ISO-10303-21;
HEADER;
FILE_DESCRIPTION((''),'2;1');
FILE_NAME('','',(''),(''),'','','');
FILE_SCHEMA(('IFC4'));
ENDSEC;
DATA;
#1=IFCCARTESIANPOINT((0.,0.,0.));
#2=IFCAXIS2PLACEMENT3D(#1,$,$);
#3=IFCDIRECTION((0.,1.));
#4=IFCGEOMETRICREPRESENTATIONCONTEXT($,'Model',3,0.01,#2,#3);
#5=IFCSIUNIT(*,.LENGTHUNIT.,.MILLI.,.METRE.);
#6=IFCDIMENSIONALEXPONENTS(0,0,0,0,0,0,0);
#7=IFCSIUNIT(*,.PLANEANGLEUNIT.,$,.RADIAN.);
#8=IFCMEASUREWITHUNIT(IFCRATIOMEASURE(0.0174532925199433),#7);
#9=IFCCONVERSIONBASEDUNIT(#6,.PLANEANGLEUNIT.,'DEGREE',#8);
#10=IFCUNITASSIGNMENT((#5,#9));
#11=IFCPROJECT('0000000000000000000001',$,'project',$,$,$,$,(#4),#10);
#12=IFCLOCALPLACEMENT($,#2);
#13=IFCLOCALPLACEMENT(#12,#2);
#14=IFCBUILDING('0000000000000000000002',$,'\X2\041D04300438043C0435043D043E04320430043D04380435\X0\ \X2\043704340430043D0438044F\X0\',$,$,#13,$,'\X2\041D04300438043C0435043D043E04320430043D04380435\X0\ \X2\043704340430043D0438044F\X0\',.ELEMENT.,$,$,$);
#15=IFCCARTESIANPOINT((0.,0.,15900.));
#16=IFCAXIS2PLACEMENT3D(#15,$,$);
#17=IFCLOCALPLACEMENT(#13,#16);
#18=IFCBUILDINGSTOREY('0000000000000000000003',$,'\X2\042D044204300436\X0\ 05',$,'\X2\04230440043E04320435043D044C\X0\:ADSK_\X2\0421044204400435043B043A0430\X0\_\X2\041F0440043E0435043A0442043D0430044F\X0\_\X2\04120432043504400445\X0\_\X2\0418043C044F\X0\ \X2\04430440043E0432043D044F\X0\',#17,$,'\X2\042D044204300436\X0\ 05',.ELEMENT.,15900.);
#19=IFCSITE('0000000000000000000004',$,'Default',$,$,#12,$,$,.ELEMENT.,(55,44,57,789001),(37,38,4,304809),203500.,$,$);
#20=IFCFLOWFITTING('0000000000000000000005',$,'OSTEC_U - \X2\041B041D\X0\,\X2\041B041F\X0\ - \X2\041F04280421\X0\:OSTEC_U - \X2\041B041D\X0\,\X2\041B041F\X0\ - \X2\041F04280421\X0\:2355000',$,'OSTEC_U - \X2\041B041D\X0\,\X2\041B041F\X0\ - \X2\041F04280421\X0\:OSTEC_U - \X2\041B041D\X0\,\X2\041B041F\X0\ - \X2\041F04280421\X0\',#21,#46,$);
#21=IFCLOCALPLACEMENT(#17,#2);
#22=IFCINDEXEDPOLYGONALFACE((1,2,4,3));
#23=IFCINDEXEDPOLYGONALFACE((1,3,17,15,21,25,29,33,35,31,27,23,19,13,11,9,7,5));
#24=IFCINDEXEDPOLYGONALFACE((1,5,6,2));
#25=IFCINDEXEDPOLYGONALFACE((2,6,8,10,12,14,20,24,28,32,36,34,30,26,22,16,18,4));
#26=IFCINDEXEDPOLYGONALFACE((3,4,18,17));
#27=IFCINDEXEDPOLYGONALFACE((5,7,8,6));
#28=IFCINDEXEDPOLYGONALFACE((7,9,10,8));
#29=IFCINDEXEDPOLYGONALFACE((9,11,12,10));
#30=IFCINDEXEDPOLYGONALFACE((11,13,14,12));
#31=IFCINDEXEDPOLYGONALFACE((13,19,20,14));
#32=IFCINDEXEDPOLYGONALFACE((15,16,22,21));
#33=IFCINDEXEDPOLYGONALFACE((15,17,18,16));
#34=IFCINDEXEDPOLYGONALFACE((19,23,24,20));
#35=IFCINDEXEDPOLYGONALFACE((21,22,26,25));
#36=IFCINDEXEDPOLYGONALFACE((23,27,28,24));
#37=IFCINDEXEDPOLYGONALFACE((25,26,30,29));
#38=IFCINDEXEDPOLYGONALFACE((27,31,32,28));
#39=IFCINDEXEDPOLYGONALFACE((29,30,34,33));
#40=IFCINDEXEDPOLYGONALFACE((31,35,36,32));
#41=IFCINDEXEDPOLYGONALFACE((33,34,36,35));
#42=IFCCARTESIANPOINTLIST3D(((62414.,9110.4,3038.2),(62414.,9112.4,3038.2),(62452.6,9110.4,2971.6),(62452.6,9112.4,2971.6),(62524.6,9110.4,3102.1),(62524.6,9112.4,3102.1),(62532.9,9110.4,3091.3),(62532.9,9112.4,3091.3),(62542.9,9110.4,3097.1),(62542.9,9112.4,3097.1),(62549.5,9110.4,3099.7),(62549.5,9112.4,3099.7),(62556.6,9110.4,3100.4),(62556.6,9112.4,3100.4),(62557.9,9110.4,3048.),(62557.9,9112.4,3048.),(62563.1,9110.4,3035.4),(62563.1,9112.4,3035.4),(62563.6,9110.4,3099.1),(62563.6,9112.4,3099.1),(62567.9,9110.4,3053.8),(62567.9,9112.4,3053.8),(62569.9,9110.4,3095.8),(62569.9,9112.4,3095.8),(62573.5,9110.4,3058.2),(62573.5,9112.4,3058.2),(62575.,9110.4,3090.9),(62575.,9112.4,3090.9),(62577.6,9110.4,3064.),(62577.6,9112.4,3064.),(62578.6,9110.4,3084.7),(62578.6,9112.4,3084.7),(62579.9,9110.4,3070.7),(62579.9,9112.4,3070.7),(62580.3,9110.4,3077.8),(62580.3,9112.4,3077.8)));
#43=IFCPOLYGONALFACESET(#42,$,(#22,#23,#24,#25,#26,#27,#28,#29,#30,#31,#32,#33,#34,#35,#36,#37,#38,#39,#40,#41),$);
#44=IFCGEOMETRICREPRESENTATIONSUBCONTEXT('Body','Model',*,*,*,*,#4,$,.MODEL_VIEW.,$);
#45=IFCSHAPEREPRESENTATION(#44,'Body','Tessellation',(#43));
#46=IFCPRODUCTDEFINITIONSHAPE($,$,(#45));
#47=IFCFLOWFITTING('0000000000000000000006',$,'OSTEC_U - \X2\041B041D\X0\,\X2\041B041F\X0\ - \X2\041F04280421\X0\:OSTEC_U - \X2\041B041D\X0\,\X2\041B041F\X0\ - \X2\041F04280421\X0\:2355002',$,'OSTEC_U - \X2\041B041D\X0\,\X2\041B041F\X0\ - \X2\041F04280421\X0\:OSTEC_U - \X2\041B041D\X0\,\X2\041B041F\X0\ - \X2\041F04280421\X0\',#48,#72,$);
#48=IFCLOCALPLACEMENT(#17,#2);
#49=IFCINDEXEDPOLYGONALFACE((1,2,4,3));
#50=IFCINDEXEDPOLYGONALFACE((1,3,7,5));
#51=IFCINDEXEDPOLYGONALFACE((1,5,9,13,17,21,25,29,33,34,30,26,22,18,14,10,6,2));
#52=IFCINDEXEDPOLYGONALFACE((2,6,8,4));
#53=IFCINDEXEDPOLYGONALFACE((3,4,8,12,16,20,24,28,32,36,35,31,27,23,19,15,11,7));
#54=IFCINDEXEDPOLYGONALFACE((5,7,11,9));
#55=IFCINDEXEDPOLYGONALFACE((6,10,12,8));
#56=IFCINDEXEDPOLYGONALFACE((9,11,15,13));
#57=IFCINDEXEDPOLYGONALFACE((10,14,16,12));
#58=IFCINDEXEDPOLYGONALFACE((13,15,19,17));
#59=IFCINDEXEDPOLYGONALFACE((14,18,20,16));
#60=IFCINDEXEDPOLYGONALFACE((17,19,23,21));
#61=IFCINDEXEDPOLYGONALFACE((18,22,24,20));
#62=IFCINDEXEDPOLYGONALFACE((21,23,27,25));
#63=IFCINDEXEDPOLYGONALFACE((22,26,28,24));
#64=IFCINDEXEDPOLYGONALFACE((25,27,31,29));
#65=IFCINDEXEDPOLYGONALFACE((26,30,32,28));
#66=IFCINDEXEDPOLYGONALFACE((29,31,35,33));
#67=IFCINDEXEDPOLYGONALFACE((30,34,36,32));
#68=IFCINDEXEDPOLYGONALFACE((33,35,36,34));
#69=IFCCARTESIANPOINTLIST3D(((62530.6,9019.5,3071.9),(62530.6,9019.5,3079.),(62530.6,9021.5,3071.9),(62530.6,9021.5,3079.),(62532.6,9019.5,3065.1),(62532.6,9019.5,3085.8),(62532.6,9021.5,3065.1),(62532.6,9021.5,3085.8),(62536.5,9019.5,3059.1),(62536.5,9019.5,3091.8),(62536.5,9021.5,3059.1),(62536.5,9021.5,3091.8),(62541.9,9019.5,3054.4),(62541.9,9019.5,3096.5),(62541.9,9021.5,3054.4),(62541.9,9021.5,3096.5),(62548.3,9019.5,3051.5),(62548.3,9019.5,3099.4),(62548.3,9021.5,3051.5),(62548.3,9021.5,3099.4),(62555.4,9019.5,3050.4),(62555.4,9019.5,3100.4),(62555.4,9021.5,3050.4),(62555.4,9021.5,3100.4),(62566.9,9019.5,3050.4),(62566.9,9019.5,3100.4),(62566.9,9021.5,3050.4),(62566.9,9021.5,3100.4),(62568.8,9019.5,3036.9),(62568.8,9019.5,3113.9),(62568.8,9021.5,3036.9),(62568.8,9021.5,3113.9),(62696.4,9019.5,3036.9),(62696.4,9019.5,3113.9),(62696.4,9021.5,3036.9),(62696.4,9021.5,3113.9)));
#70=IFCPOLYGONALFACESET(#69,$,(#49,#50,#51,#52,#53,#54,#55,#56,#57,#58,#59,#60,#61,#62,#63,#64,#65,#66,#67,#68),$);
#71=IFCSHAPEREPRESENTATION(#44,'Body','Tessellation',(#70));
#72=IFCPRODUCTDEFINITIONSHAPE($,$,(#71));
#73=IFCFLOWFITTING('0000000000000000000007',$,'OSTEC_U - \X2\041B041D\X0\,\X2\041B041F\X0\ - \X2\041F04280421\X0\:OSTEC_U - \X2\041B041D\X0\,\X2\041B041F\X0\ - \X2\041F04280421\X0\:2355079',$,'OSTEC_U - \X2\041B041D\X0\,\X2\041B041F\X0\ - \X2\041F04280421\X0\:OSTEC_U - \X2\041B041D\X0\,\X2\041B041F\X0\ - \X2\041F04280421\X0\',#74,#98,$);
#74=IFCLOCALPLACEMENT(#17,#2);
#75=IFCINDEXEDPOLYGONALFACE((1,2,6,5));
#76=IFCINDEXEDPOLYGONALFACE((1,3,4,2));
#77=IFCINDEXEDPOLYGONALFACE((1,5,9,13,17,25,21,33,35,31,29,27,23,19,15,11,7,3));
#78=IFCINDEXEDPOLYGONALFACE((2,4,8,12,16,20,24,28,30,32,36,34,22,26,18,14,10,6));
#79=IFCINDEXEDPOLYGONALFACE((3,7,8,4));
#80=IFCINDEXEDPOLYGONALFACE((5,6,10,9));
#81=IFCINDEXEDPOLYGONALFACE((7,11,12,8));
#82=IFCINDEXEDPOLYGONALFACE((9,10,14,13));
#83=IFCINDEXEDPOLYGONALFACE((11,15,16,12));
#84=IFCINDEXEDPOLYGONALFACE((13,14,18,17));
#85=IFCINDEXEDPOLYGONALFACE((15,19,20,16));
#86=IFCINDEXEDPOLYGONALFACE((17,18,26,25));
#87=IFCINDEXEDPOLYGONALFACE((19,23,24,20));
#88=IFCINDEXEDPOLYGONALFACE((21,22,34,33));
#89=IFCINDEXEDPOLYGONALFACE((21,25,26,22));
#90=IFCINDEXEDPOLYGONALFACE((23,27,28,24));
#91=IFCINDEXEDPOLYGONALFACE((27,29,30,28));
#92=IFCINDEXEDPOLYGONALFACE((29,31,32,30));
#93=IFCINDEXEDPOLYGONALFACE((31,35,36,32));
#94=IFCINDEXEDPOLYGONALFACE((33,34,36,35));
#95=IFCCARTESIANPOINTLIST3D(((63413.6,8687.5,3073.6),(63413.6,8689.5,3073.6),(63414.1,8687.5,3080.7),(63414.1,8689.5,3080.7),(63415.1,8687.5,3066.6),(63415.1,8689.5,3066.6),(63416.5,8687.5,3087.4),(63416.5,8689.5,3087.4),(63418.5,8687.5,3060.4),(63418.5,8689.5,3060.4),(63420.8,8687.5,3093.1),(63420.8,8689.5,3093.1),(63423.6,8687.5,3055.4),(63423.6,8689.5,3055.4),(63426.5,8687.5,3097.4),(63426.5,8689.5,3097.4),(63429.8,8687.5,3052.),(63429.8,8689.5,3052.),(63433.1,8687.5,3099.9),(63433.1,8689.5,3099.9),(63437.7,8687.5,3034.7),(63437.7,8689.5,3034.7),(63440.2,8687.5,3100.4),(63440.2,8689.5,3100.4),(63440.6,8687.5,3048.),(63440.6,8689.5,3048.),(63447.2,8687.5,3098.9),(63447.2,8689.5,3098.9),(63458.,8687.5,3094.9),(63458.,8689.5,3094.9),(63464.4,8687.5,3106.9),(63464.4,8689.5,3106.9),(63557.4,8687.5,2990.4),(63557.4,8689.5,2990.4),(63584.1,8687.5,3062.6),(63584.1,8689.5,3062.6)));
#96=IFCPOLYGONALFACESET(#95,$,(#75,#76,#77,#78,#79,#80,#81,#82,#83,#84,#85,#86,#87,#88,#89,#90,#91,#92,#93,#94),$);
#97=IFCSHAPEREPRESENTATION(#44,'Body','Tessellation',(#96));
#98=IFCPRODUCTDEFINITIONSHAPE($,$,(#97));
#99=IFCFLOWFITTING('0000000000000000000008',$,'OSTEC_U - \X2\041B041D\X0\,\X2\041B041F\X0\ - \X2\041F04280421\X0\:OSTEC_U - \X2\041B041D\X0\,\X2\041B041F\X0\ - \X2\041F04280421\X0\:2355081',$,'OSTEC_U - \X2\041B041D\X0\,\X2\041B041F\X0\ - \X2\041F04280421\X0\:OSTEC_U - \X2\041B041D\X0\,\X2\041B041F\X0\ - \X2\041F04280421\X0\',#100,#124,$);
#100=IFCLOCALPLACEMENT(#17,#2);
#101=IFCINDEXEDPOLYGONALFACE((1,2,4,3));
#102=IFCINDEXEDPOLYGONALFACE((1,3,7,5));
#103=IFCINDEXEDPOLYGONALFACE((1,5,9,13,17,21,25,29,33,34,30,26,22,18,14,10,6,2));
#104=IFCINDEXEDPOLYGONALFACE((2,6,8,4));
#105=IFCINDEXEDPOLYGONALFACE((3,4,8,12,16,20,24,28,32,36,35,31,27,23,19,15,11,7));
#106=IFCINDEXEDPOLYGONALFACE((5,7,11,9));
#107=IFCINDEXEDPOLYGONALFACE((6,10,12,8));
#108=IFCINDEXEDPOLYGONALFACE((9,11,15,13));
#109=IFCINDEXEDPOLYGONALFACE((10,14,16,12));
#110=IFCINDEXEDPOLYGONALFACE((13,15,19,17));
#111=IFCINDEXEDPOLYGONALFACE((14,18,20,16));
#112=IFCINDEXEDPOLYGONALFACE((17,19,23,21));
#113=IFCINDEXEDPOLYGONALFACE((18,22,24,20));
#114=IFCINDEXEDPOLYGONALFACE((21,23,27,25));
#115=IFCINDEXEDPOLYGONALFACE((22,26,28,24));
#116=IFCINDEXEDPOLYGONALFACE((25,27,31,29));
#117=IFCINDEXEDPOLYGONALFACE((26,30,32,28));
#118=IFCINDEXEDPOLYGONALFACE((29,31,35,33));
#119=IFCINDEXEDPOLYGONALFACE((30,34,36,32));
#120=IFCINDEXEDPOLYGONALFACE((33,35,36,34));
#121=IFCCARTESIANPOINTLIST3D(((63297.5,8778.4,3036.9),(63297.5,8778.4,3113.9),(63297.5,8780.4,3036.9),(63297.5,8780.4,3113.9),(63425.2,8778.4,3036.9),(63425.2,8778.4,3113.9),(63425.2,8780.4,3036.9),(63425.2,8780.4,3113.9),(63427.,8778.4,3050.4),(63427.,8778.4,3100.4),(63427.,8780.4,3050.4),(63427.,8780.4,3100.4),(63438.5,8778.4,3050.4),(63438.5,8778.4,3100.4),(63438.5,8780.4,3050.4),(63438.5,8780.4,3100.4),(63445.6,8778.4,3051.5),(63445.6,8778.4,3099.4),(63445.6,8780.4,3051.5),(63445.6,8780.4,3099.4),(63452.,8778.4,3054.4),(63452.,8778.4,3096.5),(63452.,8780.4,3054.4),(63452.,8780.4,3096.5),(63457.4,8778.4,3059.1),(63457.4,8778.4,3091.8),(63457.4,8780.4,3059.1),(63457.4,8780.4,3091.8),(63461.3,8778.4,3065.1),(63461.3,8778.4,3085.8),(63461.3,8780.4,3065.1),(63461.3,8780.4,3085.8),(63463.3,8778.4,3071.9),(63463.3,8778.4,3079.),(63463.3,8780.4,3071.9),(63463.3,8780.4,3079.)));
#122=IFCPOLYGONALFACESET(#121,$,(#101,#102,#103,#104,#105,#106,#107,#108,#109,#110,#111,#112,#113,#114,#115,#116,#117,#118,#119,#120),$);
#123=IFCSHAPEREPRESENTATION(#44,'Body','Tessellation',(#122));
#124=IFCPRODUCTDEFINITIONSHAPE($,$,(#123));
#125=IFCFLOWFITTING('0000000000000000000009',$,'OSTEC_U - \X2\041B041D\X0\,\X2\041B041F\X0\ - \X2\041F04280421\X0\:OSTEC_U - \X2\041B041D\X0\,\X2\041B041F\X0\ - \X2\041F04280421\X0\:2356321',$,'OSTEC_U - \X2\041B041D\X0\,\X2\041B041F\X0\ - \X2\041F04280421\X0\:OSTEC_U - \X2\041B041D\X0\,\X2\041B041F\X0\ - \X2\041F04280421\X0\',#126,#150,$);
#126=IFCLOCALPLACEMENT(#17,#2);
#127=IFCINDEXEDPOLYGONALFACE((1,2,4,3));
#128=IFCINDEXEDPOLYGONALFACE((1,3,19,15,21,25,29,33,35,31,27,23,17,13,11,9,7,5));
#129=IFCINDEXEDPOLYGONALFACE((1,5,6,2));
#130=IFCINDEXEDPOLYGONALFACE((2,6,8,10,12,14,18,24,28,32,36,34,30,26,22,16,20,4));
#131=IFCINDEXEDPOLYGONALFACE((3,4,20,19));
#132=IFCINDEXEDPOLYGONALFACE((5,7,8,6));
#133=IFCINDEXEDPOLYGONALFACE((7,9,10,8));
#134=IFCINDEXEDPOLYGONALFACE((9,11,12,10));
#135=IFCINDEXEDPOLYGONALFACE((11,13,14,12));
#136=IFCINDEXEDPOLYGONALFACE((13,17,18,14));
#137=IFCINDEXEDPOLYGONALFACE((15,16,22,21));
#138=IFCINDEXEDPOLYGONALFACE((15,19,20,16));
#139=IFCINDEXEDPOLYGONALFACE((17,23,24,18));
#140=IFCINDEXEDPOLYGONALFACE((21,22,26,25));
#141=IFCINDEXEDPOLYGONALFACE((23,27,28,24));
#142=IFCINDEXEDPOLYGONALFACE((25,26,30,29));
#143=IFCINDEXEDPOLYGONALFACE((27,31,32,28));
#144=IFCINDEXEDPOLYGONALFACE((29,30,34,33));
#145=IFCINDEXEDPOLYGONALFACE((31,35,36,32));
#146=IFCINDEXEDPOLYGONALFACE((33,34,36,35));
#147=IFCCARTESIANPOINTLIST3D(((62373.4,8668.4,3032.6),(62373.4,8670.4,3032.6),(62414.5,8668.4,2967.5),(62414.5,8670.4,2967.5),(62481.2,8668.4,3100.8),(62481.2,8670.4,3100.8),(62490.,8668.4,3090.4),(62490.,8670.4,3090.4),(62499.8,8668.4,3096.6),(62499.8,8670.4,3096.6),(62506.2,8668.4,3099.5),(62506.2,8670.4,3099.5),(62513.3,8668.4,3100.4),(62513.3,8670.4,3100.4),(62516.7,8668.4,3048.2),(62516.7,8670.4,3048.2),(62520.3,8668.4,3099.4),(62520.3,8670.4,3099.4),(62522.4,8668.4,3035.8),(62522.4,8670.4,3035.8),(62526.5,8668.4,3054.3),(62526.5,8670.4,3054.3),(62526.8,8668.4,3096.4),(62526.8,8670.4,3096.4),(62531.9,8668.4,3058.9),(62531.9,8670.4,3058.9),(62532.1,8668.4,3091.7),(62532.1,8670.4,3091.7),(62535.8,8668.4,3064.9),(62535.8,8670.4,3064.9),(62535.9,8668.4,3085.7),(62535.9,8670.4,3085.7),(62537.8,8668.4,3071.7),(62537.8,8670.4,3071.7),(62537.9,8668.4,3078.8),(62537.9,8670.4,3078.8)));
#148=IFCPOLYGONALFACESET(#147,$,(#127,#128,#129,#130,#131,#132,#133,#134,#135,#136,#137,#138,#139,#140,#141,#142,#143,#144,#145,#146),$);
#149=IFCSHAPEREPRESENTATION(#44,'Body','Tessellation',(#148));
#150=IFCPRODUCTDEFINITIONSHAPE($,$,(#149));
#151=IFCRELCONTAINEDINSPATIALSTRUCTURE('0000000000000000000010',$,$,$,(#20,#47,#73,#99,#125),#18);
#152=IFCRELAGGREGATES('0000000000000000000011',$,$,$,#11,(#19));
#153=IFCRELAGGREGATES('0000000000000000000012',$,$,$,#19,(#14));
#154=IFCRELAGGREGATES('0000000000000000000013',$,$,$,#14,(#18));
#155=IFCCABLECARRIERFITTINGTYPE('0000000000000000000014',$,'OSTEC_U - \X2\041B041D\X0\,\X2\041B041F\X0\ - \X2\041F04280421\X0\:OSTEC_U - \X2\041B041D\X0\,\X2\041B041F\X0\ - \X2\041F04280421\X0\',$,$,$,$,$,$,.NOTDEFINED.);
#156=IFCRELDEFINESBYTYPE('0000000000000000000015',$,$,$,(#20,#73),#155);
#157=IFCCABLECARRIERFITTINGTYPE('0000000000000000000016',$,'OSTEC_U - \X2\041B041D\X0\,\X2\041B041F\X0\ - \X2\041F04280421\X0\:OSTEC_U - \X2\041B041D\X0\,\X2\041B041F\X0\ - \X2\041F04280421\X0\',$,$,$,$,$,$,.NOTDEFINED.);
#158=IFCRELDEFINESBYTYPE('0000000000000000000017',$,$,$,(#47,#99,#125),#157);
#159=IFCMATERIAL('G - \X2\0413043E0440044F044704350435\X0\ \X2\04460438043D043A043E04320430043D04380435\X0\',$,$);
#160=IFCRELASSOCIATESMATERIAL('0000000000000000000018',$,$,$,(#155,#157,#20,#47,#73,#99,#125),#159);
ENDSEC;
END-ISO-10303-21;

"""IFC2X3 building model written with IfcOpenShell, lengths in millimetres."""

from ifc_helpers import new_model, entity, si_unit, converted_unit, direction, frame, frame_2d, origin, place, context, subcontext, project, spatial, polyline, circle_curve, parameter, trimmed, segment, composite_curve, outline, extrude, source, transform, mapped, material, type_object, type_shapes, element, save


model = new_model("IFC2X3")

# Units and contexts
model_context = context("Model", 3, precision=0.01, world=origin(), true_north=direction((0.0, 1.0)))
body_context = subcontext(model_context, "Body", "Model", "MODEL_VIEW")
ifc_project = project(units=[si_unit("LENGTHUNIT", "METRE", prefix="MILLI"), converted_unit("PLANEANGLEUNIT", "DEGREE", entity("IfcRatioMeasure", 0.0174532925199433), si_unit("PLANEANGLEUNIT", "RADIAN"), dimensions=[0, 0, 0, 0, 0, 0, 0])], contexts=[model_context])

# Site, building, storey
site_placement = place(None, origin())
site = spatial("IfcSite", under=ifc_project, at=site_placement, Name="Default", CompositionType="ELEMENT", RefLatitude=(55, 44, 57, 789001), RefLongitude=(37, 38, 4, 304809), RefElevation=203500.0)
building_placement = place(site_placement, origin())
building = spatial("IfcBuilding", under=site, at=building_placement, Name="Наименование здания", LongName="Наименование здания", CompositionType="ELEMENT")
storey_placement = place(building_placement, frame((0.0, 0.0, 15900.0)))
storey = spatial("IfcBuildingStorey", under=building, at=storey_placement, Name="Этаж 05", ObjectType="Уровень:ADSK_Стрелка_Проектная_Вверх_Имя уровня", LongName="Этаж 05", CompositionType="ELEMENT", Elevation=15900.0)

# Flow fittings
ifc_material_1 = material(Name="G - Горячее цинкование")
cable_carrier_fitting_type_1 = type_object("IfcCableCarrierFittingType", Name="OSTEC_U - ЛН,ЛП - ПШС:OSTEC_U - ЛН,ЛП - ПШС", PredefinedType="NOTDEFINED", material=ifc_material_1)
shared_shape_1 = source(origin(), body_context, "Body", "SweptSolid", [
    extrude(outline(composite_curve([segment(trimmed(circle_curve(frame_2d((-41.5, 0.0), x_axis=(1.0, 0.0)), 25.0), [parameter(90.0)], [parameter(270.0)], True, "PARAMETER"), True, "CONTINUOUS"), segment(polyline([(-41.5, -25.0), (-30.0, -25.0)]), True, "CONTINUOUS"), segment(polyline([(-30.0, -25.0), (-28.1, -38.5)]), True, "CONTINUOUS"), segment(polyline([(-28.1, -38.5), (99.5, -38.5)]), True, "CONTINUOUS"), segment(polyline([(99.5, -38.5), (99.5, 38.5)]), True, "CONTINUOUS"), segment(polyline([(99.5, 38.5), (-28.1, 38.5)]), True, "CONTINUOUS"), segment(polyline([(-28.1, 38.5), (-30.0, 25.0)]), True, "CONTINUOUS"), segment(polyline([(-30.0, 25.0), (-41.5, 25.0)]), True, "CONTINUOUS")], self_intersect=False)), frame((41.5, 0.0, 0.0)), (0.0, 0.0, 1.0), 2.0),
])
type_shapes(cable_carrier_fitting_type_1, [shared_shape_1])
cable_carrier_fitting_type_2 = type_object("IfcCableCarrierFittingType", Name="OSTEC_U - ЛН,ЛП - ПШС:OSTEC_U - ЛН,ЛП - ПШС", PredefinedType="NOTDEFINED", material=ifc_material_1)
type_shapes(cable_carrier_fitting_type_2, [shared_shape_1])
flow_fitting_1_placement = place(storey_placement, frame((62555.4, 9110.4, 3075.4), z_axis=(0.0, 1.0, 0.0), x_axis=(-0.865893, 0.0, -0.500229)))
element("IfcFlowFitting", 1, at=flow_fitting_1_placement, inside=storey, type_object=cable_carrier_fitting_type_1, material=ifc_material_1, Name="OSTEC_U - ЛН,ЛП - ПШС:OSTEC_U - ЛН,ЛП - ПШС:2355000", ObjectType="OSTEC_U - ЛН,ЛП - ПШС:OSTEC_U - ЛН,ЛП - ПШС", context=body_context, shape_type="MappedRepresentation", body=[
    mapped(shared_shape_1, transform((0.0, 0.0, 0.0), scale=1.0)),
])
flow_fitting_2_placement = place(storey_placement, frame((62555.4, 9021.5, 3075.4), z_axis=(0.0, -1.0, 0.0), x_axis=(1.0, 0.0, 0.0)))
element("IfcFlowFitting", 2, at=flow_fitting_2_placement, inside=storey, type_object=cable_carrier_fitting_type_2, material=ifc_material_1, Name="OSTEC_U - ЛН,ЛП - ПШС:OSTEC_U - ЛН,ЛП - ПШС:2355002", ObjectType="OSTEC_U - ЛН,ЛП - ПШС:OSTEC_U - ЛН,ЛП - ПШС", context=body_context, shape_type="MappedRepresentation", body=[
    mapped(shared_shape_1, transform((0.0, 0.0, 0.0), scale=1.0)),
])
flow_fitting_3_placement = place(storey_placement, frame((63438.5, 8689.5, 3075.4), z_axis=(0.0, -1.0, 0.0), x_axis=(0.937802, 0.0, -0.347171)))
element("IfcFlowFitting", 3, at=flow_fitting_3_placement, inside=storey, type_object=cable_carrier_fitting_type_1, material=ifc_material_1, Name="OSTEC_U - ЛН,ЛП - ПШС:OSTEC_U - ЛН,ЛП - ПШС:2355079", ObjectType="OSTEC_U - ЛН,ЛП - ПШС:OSTEC_U - ЛН,ЛП - ПШС", context=body_context, shape_type="MappedRepresentation", body=[
    mapped(shared_shape_1, transform((0.0, 0.0, 0.0), scale=1.0)),
])
for number, where, z_axis, x_axis, name in (
    (4, (63438.5, 8778.4, 3075.4), (0.0, 1.0, 0.0), (-1.0, 0.0, 0.0), "OSTEC_U - ЛН,ЛП - ПШС:OSTEC_U - ЛН,ЛП - ПШС:2355081"),
    (5, (62513.1, 8668.4, 3075.4), (0.0, 1.0, 0.0), (-0.84524, 0.0, -0.534387), "OSTEC_U - ЛН,ЛП - ПШС:OSTEC_U - ЛН,ЛП - ПШС:2356321"),
):
    element("IfcFlowFitting", number, at=place(storey_placement, frame(where, z_axis=z_axis, x_axis=x_axis)), inside=storey, type_object=cable_carrier_fitting_type_2, material=ifc_material_1, Name=name, ObjectType="OSTEC_U - ЛН,ЛП - ПШС:OSTEC_U - ЛН,ЛП - ПШС", context=body_context, shape_type="MappedRepresentation", body=[
        mapped(shared_shape_1, transform((0.0, 0.0, 0.0), scale=1.0)),
    ])

save(model, "model.ifc")
